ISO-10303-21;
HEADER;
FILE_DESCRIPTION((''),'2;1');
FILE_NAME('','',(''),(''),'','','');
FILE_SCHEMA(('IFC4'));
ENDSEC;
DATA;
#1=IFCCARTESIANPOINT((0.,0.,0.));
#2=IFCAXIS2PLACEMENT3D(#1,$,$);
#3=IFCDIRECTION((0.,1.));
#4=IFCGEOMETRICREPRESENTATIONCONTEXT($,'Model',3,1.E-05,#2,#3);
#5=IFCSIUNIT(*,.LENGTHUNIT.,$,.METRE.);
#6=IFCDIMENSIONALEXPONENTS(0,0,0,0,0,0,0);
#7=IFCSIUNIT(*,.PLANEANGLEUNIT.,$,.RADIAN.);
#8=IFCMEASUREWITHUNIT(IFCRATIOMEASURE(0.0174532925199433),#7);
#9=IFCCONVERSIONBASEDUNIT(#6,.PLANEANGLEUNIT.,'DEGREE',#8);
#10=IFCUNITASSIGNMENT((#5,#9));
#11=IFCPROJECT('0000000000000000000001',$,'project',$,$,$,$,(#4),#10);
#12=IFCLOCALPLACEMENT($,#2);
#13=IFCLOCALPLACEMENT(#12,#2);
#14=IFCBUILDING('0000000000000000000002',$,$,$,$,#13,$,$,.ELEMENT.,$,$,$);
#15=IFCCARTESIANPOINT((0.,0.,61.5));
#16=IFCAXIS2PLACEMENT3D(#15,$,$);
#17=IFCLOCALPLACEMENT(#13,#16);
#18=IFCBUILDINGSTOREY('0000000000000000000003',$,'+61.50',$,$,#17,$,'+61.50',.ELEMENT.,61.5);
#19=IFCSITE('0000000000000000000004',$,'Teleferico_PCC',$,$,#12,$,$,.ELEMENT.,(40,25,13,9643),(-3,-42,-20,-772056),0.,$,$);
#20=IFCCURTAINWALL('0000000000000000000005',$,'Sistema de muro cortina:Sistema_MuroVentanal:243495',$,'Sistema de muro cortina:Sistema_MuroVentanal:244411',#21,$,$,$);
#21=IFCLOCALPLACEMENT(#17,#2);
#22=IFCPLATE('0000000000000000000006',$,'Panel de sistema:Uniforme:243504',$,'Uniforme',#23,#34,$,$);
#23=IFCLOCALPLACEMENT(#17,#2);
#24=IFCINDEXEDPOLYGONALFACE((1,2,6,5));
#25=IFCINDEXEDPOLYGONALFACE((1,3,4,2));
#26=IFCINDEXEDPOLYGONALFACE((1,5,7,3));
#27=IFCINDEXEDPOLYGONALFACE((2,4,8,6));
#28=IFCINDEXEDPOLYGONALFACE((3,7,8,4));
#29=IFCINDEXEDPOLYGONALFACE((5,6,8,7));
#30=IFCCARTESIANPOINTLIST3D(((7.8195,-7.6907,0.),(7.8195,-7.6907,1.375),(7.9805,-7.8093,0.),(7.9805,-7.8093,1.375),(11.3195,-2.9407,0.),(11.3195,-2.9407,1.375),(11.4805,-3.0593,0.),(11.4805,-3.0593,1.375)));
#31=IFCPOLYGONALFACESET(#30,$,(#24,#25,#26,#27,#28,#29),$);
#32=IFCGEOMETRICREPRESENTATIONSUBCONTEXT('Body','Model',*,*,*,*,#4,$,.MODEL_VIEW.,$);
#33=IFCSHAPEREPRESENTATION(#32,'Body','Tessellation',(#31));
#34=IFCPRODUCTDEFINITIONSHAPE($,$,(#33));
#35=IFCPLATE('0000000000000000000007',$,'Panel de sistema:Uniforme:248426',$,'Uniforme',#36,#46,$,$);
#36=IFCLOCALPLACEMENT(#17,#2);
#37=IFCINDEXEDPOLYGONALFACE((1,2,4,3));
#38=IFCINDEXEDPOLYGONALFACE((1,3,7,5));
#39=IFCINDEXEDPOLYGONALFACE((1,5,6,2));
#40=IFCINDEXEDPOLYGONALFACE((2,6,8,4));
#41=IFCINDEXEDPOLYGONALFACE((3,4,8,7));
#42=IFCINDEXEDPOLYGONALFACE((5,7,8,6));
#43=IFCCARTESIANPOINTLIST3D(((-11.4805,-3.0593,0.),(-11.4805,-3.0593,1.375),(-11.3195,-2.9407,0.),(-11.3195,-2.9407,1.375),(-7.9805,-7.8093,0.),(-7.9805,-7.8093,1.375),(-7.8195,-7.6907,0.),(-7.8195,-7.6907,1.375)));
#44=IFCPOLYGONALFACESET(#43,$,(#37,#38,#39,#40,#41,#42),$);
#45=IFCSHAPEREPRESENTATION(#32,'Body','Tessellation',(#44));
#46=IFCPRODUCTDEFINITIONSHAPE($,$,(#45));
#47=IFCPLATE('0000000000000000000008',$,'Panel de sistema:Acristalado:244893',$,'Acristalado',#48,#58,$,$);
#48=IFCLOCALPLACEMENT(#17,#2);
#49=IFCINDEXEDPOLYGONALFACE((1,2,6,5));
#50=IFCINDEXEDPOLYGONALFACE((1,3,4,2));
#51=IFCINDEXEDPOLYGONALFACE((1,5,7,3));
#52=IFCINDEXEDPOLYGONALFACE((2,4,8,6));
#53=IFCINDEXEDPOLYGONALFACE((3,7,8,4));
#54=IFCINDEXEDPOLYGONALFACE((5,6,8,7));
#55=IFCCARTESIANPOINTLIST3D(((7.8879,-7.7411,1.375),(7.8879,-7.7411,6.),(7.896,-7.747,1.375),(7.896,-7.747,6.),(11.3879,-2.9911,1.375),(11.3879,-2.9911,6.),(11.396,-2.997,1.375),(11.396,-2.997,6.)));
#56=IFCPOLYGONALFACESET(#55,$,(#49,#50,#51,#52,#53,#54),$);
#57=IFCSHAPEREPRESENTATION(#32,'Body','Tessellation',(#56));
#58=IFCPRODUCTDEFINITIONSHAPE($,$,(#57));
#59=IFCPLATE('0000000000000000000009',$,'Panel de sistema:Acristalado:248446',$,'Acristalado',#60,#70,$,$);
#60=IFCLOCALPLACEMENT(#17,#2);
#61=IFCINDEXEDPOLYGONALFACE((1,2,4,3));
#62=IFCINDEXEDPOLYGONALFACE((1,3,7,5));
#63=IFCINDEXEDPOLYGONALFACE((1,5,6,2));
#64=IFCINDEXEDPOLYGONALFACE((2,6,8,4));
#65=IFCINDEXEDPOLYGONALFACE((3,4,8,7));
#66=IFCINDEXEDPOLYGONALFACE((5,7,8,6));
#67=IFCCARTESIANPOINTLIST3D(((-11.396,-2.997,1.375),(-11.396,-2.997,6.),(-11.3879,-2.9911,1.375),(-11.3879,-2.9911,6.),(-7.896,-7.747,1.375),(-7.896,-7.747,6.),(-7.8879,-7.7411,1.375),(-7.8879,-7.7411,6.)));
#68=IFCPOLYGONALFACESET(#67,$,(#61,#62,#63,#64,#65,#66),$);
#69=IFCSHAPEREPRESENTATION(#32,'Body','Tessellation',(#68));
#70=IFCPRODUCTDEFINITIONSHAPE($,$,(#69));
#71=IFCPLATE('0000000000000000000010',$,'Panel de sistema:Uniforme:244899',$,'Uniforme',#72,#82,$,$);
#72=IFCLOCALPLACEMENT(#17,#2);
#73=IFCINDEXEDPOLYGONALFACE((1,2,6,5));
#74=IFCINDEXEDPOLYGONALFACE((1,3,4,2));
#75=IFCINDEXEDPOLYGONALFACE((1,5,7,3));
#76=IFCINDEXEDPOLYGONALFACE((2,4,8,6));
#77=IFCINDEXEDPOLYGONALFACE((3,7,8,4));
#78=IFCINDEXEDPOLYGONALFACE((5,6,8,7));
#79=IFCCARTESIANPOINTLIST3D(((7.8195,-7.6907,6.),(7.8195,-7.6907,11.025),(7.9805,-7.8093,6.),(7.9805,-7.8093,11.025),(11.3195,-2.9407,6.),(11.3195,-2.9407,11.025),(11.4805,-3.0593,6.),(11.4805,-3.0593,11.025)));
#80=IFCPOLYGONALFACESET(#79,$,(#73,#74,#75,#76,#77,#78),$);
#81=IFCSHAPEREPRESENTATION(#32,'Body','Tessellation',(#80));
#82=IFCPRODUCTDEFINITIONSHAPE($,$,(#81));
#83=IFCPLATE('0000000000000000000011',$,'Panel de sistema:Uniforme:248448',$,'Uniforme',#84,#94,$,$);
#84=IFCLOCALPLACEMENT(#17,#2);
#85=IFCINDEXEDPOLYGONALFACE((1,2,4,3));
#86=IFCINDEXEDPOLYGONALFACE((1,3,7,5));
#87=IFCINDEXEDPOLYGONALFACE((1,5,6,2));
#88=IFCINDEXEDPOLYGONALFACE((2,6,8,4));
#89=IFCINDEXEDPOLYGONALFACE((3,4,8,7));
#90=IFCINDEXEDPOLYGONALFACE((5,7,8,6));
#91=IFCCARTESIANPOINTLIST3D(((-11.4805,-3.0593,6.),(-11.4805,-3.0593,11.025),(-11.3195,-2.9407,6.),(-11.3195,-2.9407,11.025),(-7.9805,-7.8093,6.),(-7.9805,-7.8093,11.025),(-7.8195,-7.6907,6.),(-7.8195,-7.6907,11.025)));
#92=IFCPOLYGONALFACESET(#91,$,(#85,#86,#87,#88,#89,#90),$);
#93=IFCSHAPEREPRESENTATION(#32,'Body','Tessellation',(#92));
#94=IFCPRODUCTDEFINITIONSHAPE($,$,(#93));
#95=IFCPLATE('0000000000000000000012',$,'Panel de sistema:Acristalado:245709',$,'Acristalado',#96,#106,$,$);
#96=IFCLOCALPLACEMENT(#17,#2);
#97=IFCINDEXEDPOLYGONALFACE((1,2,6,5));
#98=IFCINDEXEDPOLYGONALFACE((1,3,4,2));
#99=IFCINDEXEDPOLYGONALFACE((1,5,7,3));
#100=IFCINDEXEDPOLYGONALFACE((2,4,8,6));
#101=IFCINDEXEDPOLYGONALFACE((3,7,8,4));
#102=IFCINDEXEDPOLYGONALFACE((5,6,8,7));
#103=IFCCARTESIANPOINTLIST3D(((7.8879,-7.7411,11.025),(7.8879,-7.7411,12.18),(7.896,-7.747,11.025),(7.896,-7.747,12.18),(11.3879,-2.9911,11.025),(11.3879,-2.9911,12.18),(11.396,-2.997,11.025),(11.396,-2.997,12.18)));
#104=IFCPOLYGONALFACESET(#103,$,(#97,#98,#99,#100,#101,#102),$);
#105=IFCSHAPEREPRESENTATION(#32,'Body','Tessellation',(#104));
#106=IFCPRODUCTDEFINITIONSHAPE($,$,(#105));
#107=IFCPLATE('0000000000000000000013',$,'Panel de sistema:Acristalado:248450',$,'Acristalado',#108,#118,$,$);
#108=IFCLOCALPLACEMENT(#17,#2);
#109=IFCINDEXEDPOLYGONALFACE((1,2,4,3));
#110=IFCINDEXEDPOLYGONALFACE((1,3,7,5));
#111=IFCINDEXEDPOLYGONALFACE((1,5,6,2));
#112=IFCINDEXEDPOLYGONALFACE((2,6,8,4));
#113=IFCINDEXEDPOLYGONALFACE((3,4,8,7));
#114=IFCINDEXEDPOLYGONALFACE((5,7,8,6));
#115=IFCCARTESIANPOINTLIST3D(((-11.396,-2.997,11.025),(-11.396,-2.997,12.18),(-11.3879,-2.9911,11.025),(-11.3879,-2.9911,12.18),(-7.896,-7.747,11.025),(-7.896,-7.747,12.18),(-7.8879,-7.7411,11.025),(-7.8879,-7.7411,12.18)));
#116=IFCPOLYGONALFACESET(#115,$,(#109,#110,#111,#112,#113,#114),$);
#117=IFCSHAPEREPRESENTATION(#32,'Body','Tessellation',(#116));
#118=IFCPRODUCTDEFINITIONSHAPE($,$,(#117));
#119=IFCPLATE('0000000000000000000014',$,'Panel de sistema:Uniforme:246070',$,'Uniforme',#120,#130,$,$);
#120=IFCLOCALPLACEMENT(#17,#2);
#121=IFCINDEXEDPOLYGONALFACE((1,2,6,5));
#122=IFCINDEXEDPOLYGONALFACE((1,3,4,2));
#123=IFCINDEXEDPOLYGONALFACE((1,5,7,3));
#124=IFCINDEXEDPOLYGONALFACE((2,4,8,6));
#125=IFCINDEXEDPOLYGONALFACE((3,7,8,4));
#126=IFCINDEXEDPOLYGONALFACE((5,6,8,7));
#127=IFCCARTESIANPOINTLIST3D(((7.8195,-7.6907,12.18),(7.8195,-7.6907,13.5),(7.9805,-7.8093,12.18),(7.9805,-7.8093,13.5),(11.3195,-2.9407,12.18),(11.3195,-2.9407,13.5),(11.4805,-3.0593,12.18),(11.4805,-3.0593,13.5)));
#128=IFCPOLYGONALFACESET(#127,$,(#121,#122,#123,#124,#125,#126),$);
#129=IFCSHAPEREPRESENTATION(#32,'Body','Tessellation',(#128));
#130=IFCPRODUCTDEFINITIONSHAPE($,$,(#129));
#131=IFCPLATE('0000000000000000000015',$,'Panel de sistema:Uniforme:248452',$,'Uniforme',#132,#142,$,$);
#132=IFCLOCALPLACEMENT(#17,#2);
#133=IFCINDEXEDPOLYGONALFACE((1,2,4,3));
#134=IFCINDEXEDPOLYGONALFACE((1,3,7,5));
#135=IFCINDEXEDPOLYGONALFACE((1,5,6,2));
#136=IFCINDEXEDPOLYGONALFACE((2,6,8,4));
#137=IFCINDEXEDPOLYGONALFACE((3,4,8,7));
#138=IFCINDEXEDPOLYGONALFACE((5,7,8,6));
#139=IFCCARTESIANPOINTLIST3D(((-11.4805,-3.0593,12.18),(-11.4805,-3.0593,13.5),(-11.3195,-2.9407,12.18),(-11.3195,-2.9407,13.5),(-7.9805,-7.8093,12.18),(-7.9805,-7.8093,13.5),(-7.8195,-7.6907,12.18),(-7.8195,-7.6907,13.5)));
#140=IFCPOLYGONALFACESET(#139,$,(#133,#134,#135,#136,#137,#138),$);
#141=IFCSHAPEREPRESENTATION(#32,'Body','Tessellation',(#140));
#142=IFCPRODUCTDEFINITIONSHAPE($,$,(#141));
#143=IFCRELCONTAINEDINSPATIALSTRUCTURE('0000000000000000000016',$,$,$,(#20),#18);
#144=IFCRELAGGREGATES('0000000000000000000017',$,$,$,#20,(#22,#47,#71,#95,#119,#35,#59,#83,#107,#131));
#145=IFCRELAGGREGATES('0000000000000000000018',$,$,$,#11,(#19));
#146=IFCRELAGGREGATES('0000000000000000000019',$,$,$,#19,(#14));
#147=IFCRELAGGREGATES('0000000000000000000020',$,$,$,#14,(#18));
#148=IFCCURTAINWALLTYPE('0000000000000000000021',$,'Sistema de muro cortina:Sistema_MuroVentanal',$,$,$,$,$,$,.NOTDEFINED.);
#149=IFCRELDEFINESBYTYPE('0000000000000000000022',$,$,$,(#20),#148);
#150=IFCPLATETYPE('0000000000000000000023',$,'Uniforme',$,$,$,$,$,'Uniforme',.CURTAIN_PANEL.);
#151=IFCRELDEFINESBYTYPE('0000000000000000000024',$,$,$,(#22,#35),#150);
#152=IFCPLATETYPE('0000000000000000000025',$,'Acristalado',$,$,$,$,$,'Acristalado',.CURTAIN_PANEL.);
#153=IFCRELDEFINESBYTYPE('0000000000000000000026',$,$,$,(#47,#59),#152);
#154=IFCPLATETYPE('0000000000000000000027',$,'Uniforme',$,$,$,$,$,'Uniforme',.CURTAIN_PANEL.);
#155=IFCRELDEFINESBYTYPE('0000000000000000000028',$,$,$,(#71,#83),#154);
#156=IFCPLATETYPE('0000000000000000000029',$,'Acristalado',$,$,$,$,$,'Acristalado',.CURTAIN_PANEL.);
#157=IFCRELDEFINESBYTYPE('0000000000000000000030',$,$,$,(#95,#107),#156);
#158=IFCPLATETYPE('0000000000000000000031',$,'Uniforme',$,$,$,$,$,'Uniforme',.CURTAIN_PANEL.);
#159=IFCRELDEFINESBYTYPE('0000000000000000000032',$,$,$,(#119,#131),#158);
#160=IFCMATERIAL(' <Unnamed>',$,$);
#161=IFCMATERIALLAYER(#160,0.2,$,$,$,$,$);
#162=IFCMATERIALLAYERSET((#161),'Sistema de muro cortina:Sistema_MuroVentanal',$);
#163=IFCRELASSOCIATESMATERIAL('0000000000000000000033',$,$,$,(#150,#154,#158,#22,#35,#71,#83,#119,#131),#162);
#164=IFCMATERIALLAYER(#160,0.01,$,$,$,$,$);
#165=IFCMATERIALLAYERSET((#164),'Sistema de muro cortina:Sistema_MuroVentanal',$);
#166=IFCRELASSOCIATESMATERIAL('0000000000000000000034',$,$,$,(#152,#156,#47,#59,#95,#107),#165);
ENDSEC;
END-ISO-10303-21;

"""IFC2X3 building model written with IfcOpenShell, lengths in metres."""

from ifc_helpers import new_model, entity, si_unit, converted_unit, direction, frame, frame_2d, origin, origin_2d_with_axis, place, context, subcontext, project, spatial, rectangle, extrude, source, transform, mapped, material, layer, layer_set, layer_usage, type_object, type_shapes, element, aggregate, save


model = new_model("IFC2X3")

# Units and contexts
model_context = context("Model", 3, precision=1e-05, world=origin(), true_north=direction((0.0, 1.0)))
body_context = subcontext(model_context, "Body", "Model", "MODEL_VIEW")
ifc_project = project(units=[si_unit("LENGTHUNIT", "METRE"), converted_unit("PLANEANGLEUNIT", "DEGREE", entity("IfcRatioMeasure", 0.0174532925199433), si_unit("PLANEANGLEUNIT", "RADIAN"), dimensions=[0, 0, 0, 0, 0, 0, 0])], contexts=[model_context])

# Site, building, storey
site_placement = place(None, origin())
site = spatial("IfcSite", under=ifc_project, at=site_placement, Name="Teleferico_PCC", CompositionType="ELEMENT", RefLatitude=(40, 25, 13, 9643), RefLongitude=(-3, -42, -20, -772056), RefElevation=0.0)
building_placement = place(site_placement, origin())
building = spatial("IfcBuilding", under=site, at=building_placement, CompositionType="ELEMENT")
storey_placement = place(building_placement, frame((0.0, 0.0, 61.5)))
storey = spatial("IfcBuildingStorey", under=building, at=storey_placement, Name="+61.50", LongName="+61.50", CompositionType="ELEMENT", Elevation=61.5)

# Curtain wall, plates
curtain_wall_type = type_object("IfcCurtainWallType", Name="Sistema de muro cortina:Sistema_MuroVentanal", PredefinedType="NOTDEFINED")
curtain_wall_placement = place(storey_placement, frame((0.0, 0.0, -61.5)))
curtain_wall = element("IfcCurtainWall", 1, at=curtain_wall_placement, inside=storey, type_object=curtain_wall_type, Name="Sistema de muro cortina:Sistema_MuroVentanal:243495", ObjectType="Sistema de muro cortina:Sistema_MuroVentanal:244411")
ifc_material = material(Name=" <Unnamed>")
ifc_layer_1 = layer(ifc_material, 0.2)
ifc_layer_set_1 = layer_set([ifc_layer_1], Name="Sistema de muro cortina:Sistema_MuroVentanal")
ifc_layer_2 = layer(ifc_material, 0.01)
ifc_layer_set_2 = layer_set([ifc_layer_2], Name="Sistema de muro cortina:Sistema_MuroVentanal")
ifc_layer_usage_1 = layer_usage(ifc_layer_set_1, "AXIS3", "POSITIVE", 0.0)
plate_type_1 = type_object("IfcPlateType", Name="Uniforme", ElementType="Uniforme", PredefinedType="CURTAIN_PANEL", material=ifc_layer_set_1)
shared_shape_1 = source(origin(), body_context, "Body", "SweptSolid", [
    extrude(rectangle(XDim=0.2, YDim=5.9002, at=origin_2d_with_axis()), frame((0.0, 0.0, 0.0), z_axis=(0.0, 0.0, 1.0), x_axis=(0.0, 1.0, 0.0)), (0.0, 0.0, 1.0), 1.375),
])
type_shapes(plate_type_1, [shared_shape_1])
plate_1_placement = place(curtain_wall_placement, frame((9.65, -5.375, 61.5), z_axis=(0.0, 0.0, 1.0), x_axis=(-0.593199, -0.805056, 0.0)))
plate_1 = element("IfcPlate", 2, at=plate_1_placement, type_object=plate_type_1, material=ifc_layer_usage_1, Name="Panel de sistema:Uniforme:243504", ObjectType="Uniforme", context=body_context, shape_type="MappedRepresentation", body=[
    mapped(shared_shape_1, transform((0.0, 0.0, 0.0), scale=1.0)),
])
ifc_layer_usage_2 = layer_usage(ifc_layer_set_1, "AXIS3", "POSITIVE", 0.0)
plate_2_placement = place(curtain_wall_placement, frame((-9.65, -5.375, 61.5), z_axis=(0.0, 0.0, 1.0), x_axis=(-0.593199, 0.805056, 0.0)))
plate_2 = element("IfcPlate", 3, at=plate_2_placement, type_object=plate_type_1, material=ifc_layer_usage_2, Name="Panel de sistema:Uniforme:248426", ObjectType="Uniforme", context=body_context, shape_type="MappedRepresentation", body=[
    mapped(shared_shape_1, transform((0.0, 0.0, 0.0), scale=1.0)),
])
ifc_layer_usage_3 = layer_usage(ifc_layer_set_2, "AXIS3", "POSITIVE", -0.0328)
plate_type_2 = type_object("IfcPlateType", Name="Acristalado", ElementType="Acristalado", PredefinedType="CURTAIN_PANEL", material=ifc_layer_set_2)
shared_shape_2 = source(origin(), body_context, "Body", "SweptSolid", [
    extrude(rectangle(XDim=0.01, YDim=5.9002, at=origin_2d_with_axis()), frame((2.9501, 0.005, 0.0), z_axis=(0.0, 0.0, 1.0), x_axis=(0.0, 1.0, 0.0)), (0.0, 0.0, 1.0), 4.625),
])
type_shapes(plate_type_2, [shared_shape_2])
plate_3_placement = place(curtain_wall_placement, frame((11.3879, -2.9911, 62.875), z_axis=(0.0, 0.0, 1.0), x_axis=(-0.593199, -0.805056, 0.0)))
plate_3 = element("IfcPlate", 4, at=plate_3_placement, type_object=plate_type_2, material=ifc_layer_usage_3, Name="Panel de sistema:Acristalado:244893", ObjectType="Acristalado", context=body_context, shape_type="MappedRepresentation", body=[
    mapped(shared_shape_2, transform((0.0, 0.0, 0.0), scale=1.0)),
])
ifc_layer_usage_4 = layer_usage(ifc_layer_set_2, "AXIS3", "POSITIVE", -0.0328)
plate_4_placement = place(curtain_wall_placement, frame((-7.8879, -7.7411, 62.875), z_axis=(0.0, 0.0, 1.0), x_axis=(-0.593199, 0.805056, 0.0)))
plate_4 = element("IfcPlate", 5, at=plate_4_placement, type_object=plate_type_2, material=ifc_layer_usage_4, Name="Panel de sistema:Acristalado:248446", ObjectType="Acristalado", context=body_context, shape_type="MappedRepresentation", body=[
    mapped(shared_shape_2, transform((0.0, 0.0, 0.0), scale=1.0)),
])
ifc_layer_usage_5 = layer_usage(ifc_layer_set_1, "AXIS3", "POSITIVE", 0.0)
plate_type_3 = type_object("IfcPlateType", Name="Uniforme", ElementType="Uniforme", PredefinedType="CURTAIN_PANEL", material=ifc_layer_set_1)
shared_shape_3 = source(origin(), body_context, "Body", "SweptSolid", [
    extrude(rectangle(XDim=0.2, YDim=5.9002, at=origin_2d_with_axis()), frame((0.0, 0.0, 0.0), z_axis=(0.0, 0.0, 1.0), x_axis=(0.0, 1.0, 0.0)), (0.0, 0.0, 1.0), 5.025),
])
type_shapes(plate_type_3, [shared_shape_3])
plate_5_placement = place(curtain_wall_placement, frame((9.65, -5.375, 67.5), z_axis=(0.0, 0.0, 1.0), x_axis=(-0.593199, -0.805056, 0.0)))
plate_5 = element("IfcPlate", 6, at=plate_5_placement, type_object=plate_type_3, material=ifc_layer_usage_5, Name="Panel de sistema:Uniforme:244899", ObjectType="Uniforme", context=body_context, shape_type="MappedRepresentation", body=[
    mapped(shared_shape_3, transform((0.0, 0.0, 0.0), scale=1.0)),
])
ifc_layer_usage_6 = layer_usage(ifc_layer_set_1, "AXIS3", "POSITIVE", 0.0)
plate_6_placement = place(curtain_wall_placement, frame((-9.65, -5.375, 67.5), z_axis=(0.0, 0.0, 1.0), x_axis=(-0.593199, 0.805056, 0.0)))
plate_6 = element("IfcPlate", 7, at=plate_6_placement, type_object=plate_type_3, material=ifc_layer_usage_6, Name="Panel de sistema:Uniforme:248448", ObjectType="Uniforme", context=body_context, shape_type="MappedRepresentation", body=[
    mapped(shared_shape_3, transform((0.0, 0.0, 0.0), scale=1.0)),
])
ifc_layer_usage_7 = layer_usage(ifc_layer_set_2, "AXIS3", "POSITIVE", -0.0328)
plate_type_4 = type_object("IfcPlateType", Name="Acristalado", ElementType="Acristalado", PredefinedType="CURTAIN_PANEL", material=ifc_layer_set_2)
shared_shape_4 = source(origin(), body_context, "Body", "SweptSolid", [
    extrude(rectangle(XDim=0.01, YDim=5.9002, at=frame_2d((0.0, 0.0), x_axis=(1.0, 0.0))), frame((2.9501, 0.005, 0.0), z_axis=(0.0, 0.0, 1.0), x_axis=(0.0, 1.0, 0.0)), (0.0, 0.0, 1.0), 1.155),
])
type_shapes(plate_type_4, [shared_shape_4])
plate_7_placement = place(curtain_wall_placement, frame((11.3879, -2.9911, 72.525), z_axis=(0.0, 0.0, 1.0), x_axis=(-0.593199, -0.805056, 0.0)))
plate_7 = element("IfcPlate", 8, at=plate_7_placement, type_object=plate_type_4, material=ifc_layer_usage_7, Name="Panel de sistema:Acristalado:245709", ObjectType="Acristalado", context=body_context, shape_type="MappedRepresentation", body=[
    mapped(shared_shape_4, transform((0.0, 0.0, 0.0), scale=1.0)),
])
ifc_layer_usage_8 = layer_usage(ifc_layer_set_2, "AXIS3", "POSITIVE", -0.0328)
plate_8_placement = place(curtain_wall_placement, frame((-7.8879, -7.7411, 72.525), z_axis=(0.0, 0.0, 1.0), x_axis=(-0.593199, 0.805056, 0.0)))
plate_8 = element("IfcPlate", 9, at=plate_8_placement, type_object=plate_type_4, material=ifc_layer_usage_8, Name="Panel de sistema:Acristalado:248450", ObjectType="Acristalado", context=body_context, shape_type="MappedRepresentation", body=[
    mapped(shared_shape_4, transform((0.0, 0.0, 0.0), scale=1.0)),
])
ifc_layer_usage_9 = layer_usage(ifc_layer_set_1, "AXIS3", "POSITIVE", 0.0)
plate_type_5 = type_object("IfcPlateType", Name="Uniforme", ElementType="Uniforme", PredefinedType="CURTAIN_PANEL", material=ifc_layer_set_1)
shared_shape_5 = source(origin(), body_context, "Body", "SweptSolid", [
    extrude(rectangle(XDim=0.2, YDim=5.9002, at=origin_2d_with_axis()), frame((0.0, 0.0, 0.0), z_axis=(0.0, 0.0, 1.0), x_axis=(0.0, 1.0, 0.0)), (0.0, 0.0, 1.0), 1.32),
])
type_shapes(plate_type_5, [shared_shape_5])
plate_9_placement = place(curtain_wall_placement, frame((9.65, -5.375, 73.68), z_axis=(0.0, 0.0, 1.0), x_axis=(-0.593199, -0.805056, 0.0)))
plate_9 = element("IfcPlate", 10, at=plate_9_placement, type_object=plate_type_5, material=ifc_layer_usage_9, Name="Panel de sistema:Uniforme:246070", ObjectType="Uniforme", context=body_context, shape_type="MappedRepresentation", body=[
    mapped(shared_shape_5, transform((0.0, 0.0, 0.0), scale=1.0)),
])
ifc_layer_usage_10 = layer_usage(ifc_layer_set_1, "AXIS3", "POSITIVE", 0.0)
plate_10_placement = place(curtain_wall_placement, frame((-9.65, -5.375, 73.68), z_axis=(0.0, 0.0, 1.0), x_axis=(-0.593199, 0.805056, 0.0)))
plate_10 = element("IfcPlate", 11, at=plate_10_placement, type_object=plate_type_5, material=ifc_layer_usage_10, Name="Panel de sistema:Uniforme:248452", ObjectType="Uniforme", context=body_context, shape_type="MappedRepresentation", body=[
    mapped(shared_shape_5, transform((0.0, 0.0, 0.0), scale=1.0)),
])
aggregate(curtain_wall, [plate_1, plate_3, plate_5, plate_7, plate_9, plate_2, plate_4, plate_6, plate_8, plate_10])

save(model, "model.ifc")
